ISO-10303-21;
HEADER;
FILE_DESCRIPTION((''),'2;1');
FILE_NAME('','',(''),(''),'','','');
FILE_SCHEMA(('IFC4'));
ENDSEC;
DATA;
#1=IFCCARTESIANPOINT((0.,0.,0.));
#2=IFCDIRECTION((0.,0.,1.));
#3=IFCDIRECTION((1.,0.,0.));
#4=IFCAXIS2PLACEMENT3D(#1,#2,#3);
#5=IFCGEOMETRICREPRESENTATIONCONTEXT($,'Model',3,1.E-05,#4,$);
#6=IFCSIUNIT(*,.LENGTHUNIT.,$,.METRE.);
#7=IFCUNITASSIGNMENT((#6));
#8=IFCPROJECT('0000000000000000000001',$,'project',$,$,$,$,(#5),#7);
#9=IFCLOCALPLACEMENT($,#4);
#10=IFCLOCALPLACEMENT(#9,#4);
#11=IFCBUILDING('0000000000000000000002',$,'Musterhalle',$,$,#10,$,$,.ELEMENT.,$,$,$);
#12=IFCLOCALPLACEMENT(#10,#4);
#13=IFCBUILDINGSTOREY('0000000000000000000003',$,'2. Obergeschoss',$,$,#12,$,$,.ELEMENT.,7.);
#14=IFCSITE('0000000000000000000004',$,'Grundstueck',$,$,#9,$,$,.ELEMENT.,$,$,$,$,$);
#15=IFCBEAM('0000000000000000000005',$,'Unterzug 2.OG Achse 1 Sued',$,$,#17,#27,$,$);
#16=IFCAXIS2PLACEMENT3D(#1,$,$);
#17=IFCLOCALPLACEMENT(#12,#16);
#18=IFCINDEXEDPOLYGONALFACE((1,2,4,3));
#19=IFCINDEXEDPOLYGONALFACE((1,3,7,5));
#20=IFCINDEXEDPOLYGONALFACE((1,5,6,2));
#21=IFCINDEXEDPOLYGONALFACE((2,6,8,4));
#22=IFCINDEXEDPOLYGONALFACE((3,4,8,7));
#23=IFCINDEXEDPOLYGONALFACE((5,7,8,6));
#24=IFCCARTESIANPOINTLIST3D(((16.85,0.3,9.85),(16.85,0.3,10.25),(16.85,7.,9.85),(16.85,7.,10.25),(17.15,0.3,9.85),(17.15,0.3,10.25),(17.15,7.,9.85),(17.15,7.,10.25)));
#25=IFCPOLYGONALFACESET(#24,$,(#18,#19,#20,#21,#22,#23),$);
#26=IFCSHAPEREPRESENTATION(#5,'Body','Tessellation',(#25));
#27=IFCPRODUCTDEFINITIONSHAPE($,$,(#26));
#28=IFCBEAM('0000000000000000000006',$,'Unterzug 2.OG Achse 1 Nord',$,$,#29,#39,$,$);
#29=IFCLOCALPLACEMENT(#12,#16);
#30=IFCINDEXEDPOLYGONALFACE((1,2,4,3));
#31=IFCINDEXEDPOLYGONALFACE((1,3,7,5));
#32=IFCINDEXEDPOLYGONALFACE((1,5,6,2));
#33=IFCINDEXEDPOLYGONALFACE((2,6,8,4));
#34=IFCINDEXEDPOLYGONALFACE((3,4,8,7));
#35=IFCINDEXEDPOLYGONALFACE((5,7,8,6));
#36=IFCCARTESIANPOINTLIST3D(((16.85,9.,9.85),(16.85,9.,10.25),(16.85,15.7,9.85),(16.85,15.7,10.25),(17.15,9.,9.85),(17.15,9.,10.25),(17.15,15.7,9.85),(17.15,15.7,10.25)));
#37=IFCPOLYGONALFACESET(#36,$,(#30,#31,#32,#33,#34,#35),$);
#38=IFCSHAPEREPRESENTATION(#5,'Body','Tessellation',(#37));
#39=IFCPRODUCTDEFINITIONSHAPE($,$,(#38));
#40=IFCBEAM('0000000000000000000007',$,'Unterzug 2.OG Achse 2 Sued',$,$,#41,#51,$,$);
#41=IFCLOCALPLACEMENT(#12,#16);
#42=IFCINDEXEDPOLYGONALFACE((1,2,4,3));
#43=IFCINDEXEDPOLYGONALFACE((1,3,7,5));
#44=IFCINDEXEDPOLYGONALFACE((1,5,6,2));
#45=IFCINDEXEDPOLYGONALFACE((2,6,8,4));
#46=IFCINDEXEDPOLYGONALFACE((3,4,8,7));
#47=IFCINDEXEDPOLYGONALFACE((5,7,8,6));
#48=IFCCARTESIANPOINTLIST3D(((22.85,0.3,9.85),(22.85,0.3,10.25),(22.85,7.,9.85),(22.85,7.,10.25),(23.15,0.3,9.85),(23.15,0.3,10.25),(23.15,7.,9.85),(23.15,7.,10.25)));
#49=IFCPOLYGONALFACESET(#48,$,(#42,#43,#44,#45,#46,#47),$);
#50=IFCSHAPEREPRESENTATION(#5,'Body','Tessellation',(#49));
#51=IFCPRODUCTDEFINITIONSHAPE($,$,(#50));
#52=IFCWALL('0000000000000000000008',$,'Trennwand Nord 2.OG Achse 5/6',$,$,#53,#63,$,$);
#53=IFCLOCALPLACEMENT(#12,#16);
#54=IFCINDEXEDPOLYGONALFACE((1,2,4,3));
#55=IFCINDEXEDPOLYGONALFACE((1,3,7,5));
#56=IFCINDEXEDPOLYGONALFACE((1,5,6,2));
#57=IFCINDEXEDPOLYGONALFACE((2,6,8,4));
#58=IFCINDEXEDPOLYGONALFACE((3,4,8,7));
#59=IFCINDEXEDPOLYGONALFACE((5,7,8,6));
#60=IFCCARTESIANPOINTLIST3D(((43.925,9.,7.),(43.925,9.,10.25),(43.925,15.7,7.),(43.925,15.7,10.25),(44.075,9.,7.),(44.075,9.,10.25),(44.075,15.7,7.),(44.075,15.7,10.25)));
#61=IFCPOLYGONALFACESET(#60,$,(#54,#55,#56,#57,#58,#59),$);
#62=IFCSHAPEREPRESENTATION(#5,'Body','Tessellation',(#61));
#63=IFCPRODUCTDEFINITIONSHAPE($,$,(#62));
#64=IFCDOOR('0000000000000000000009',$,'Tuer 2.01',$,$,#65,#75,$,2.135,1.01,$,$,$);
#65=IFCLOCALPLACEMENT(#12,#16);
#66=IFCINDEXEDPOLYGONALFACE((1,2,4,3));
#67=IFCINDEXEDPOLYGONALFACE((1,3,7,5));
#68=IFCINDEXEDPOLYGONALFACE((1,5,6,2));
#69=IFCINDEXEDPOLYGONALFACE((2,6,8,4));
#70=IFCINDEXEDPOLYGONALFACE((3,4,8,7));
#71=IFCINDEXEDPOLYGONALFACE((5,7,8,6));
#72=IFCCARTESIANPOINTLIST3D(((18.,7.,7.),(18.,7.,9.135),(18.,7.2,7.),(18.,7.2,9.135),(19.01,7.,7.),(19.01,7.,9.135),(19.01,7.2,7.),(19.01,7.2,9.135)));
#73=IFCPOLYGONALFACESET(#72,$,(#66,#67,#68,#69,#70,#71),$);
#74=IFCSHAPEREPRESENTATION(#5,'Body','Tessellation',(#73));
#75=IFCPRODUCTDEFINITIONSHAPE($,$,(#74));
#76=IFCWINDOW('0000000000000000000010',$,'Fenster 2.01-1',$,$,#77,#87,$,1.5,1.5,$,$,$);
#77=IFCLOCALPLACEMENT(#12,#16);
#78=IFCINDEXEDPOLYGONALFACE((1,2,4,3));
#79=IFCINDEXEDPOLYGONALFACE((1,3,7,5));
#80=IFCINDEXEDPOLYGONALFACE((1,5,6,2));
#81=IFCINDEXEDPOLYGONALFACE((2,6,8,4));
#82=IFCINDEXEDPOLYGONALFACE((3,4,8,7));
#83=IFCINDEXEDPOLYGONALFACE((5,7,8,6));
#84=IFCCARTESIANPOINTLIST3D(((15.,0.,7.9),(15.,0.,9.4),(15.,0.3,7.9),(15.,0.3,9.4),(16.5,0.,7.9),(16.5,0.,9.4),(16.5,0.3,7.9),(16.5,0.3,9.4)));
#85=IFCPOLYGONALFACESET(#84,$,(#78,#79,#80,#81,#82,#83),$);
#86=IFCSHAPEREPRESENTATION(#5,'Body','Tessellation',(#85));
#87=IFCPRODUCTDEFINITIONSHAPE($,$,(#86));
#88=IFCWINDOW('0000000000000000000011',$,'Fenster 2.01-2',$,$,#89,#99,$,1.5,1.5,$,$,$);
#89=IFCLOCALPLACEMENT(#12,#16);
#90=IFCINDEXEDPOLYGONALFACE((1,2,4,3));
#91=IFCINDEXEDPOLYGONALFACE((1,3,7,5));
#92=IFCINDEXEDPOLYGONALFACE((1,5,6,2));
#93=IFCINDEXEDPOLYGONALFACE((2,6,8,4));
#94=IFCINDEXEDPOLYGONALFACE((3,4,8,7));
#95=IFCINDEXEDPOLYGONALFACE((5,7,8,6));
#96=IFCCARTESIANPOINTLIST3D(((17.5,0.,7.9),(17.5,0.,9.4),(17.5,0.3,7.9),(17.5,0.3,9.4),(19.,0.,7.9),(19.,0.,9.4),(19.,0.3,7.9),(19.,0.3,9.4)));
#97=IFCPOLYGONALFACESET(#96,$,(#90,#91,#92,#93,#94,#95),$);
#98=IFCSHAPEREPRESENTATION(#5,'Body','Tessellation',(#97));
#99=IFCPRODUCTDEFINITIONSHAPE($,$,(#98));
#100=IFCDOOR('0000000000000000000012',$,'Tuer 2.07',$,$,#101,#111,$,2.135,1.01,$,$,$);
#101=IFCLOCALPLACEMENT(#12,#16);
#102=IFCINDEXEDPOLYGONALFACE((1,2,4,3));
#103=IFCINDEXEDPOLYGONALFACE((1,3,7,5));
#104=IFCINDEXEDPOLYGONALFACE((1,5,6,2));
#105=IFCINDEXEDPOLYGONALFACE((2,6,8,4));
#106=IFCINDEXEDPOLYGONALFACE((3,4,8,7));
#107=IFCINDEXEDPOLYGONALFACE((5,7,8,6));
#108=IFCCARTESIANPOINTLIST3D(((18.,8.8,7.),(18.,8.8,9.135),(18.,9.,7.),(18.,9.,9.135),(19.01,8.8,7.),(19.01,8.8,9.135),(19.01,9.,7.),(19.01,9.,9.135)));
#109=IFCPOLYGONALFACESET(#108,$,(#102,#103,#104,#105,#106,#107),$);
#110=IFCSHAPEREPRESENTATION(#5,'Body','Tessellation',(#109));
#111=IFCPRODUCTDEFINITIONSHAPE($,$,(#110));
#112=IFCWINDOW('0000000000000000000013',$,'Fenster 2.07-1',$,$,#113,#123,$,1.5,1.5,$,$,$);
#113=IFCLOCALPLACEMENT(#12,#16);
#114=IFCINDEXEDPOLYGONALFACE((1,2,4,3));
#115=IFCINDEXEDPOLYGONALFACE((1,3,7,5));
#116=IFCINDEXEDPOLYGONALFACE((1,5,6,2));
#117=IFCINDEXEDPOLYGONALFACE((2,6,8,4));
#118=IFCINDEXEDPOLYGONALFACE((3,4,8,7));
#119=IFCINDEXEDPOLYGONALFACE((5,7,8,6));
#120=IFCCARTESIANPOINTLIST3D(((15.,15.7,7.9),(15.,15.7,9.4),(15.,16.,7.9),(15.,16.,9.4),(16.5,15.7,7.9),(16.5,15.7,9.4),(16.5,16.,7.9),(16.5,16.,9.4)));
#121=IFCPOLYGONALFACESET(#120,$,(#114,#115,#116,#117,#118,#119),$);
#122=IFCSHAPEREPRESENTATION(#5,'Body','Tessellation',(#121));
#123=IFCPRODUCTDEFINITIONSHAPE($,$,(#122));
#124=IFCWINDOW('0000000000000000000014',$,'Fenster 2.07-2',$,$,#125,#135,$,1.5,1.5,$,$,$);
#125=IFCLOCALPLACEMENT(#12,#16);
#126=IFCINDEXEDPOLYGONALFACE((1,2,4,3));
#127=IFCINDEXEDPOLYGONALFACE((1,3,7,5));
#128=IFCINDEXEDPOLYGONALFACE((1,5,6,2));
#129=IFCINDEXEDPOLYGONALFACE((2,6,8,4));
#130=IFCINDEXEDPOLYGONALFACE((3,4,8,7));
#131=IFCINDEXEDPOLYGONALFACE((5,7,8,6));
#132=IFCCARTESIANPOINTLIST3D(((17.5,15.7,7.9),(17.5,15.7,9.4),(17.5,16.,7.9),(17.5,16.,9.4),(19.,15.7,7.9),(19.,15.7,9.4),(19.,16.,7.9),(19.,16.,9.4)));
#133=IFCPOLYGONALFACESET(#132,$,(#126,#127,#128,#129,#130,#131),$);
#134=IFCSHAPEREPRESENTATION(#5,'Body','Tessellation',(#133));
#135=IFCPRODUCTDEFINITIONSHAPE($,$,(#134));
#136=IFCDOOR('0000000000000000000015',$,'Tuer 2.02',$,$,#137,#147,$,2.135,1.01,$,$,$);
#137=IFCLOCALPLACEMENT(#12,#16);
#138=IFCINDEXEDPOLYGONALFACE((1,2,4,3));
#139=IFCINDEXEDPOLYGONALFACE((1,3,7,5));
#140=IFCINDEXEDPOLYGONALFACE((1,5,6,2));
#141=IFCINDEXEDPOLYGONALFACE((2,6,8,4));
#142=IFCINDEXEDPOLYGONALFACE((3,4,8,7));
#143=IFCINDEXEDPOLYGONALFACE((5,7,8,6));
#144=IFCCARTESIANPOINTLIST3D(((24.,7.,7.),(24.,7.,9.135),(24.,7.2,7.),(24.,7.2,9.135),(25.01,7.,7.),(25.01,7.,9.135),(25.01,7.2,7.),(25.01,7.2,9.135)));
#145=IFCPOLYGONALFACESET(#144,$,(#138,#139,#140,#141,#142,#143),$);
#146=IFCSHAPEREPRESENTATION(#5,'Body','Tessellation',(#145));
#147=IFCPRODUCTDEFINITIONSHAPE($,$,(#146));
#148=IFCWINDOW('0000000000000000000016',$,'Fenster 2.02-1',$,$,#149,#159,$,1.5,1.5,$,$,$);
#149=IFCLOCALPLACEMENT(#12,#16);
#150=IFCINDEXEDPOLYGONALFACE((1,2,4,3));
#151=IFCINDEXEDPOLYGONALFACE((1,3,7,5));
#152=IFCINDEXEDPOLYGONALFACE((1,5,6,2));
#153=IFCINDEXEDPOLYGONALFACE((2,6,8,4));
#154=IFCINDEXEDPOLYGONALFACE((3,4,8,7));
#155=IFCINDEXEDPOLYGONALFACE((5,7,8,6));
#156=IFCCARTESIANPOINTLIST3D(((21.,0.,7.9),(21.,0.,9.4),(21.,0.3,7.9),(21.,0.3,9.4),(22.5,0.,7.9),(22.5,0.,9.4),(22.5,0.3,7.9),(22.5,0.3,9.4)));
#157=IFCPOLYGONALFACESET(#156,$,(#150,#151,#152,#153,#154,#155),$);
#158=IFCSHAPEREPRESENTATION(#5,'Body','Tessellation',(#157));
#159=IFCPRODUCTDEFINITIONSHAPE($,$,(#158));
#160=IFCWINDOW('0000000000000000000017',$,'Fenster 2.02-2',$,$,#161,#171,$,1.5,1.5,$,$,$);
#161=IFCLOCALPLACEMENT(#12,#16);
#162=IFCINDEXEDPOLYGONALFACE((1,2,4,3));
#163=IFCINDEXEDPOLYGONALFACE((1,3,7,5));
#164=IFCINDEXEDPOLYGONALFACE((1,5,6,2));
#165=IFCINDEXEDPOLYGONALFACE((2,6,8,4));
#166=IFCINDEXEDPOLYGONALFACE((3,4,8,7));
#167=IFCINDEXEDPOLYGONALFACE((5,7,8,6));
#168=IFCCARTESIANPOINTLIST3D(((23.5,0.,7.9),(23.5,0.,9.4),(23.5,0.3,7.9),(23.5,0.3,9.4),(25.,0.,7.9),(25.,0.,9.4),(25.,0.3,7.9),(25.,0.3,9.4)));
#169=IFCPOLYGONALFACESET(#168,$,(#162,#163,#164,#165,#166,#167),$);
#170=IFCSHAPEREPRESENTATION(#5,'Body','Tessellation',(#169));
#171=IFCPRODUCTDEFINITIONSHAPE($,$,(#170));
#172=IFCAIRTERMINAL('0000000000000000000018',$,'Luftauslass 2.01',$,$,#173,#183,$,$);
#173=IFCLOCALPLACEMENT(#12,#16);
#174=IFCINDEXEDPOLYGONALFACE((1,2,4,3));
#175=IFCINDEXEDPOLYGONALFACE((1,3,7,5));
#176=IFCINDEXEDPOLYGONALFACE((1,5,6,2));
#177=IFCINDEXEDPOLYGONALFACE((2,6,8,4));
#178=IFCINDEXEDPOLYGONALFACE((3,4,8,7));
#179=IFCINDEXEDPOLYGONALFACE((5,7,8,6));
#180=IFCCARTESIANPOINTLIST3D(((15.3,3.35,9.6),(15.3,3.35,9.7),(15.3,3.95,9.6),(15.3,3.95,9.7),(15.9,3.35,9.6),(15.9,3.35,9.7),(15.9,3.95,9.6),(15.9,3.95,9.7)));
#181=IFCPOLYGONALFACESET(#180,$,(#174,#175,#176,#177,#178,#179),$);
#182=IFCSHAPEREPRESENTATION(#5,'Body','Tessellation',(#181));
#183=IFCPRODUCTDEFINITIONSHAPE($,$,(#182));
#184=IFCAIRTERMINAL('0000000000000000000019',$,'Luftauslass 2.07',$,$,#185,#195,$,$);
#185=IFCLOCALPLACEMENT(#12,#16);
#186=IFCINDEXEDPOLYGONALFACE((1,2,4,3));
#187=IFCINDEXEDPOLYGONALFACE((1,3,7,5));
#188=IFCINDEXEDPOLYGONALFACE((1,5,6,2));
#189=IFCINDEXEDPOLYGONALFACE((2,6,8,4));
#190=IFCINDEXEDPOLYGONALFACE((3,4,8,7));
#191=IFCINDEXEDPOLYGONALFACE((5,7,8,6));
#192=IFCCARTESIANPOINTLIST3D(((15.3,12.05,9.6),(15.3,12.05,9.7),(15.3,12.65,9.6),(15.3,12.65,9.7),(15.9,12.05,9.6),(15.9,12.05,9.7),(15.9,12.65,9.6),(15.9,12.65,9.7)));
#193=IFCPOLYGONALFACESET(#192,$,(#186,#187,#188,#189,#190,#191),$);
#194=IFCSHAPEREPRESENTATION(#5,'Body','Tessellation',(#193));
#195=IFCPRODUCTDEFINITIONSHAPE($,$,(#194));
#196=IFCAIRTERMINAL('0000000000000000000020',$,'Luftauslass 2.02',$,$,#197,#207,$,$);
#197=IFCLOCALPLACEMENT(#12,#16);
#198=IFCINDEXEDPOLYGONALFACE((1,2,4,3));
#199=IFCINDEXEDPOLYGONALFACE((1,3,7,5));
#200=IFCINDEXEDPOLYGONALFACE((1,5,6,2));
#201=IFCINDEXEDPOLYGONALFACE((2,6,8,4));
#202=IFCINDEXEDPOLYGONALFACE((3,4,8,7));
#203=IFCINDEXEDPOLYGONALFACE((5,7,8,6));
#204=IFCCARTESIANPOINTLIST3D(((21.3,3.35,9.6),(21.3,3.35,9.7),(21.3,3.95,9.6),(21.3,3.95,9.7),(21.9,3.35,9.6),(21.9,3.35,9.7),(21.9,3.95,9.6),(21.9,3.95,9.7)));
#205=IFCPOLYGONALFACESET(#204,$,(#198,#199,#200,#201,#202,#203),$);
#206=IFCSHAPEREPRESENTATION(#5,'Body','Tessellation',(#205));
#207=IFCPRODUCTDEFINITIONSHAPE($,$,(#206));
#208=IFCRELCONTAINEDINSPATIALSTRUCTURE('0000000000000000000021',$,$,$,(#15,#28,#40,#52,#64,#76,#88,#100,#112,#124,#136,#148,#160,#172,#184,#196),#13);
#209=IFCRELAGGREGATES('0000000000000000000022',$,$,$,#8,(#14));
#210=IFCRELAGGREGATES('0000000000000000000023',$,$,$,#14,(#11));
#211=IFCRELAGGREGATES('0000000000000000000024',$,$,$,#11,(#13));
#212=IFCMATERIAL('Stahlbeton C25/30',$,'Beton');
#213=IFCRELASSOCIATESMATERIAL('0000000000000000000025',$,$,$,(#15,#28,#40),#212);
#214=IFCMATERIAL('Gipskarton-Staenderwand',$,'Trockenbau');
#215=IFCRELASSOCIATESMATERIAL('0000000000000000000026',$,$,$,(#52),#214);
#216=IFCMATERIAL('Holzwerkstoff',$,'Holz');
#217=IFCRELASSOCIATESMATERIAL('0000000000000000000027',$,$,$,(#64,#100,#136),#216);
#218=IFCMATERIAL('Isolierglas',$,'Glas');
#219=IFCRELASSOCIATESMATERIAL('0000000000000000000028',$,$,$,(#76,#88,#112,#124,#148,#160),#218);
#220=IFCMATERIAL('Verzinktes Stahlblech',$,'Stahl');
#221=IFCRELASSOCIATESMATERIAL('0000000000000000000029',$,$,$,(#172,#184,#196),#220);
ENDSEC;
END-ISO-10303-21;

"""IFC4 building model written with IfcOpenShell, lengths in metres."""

from ifc_helpers import new_model, si_unit, frame, origin_with_axes, origin_2d, place, context, project, spatial, rectangle, extrude, material, element, save


model = new_model("IFC4")

# Units and contexts
model_context = context("Model", 3, precision=1e-05, world=origin_with_axes())
ifc_project = project(units=[si_unit("LENGTHUNIT", "METRE")], contexts=[model_context])

# Site, building, storey
site_placement = place(None, origin_with_axes())
site = spatial("IfcSite", under=ifc_project, at=site_placement, Name="Grundstueck", CompositionType="ELEMENT")
building_placement = place(site_placement, origin_with_axes())
building = spatial("IfcBuilding", under=site, at=building_placement, Name="Musterhalle", CompositionType="ELEMENT")
storey_placement = place(building_placement, origin_with_axes())
storey = spatial("IfcBuildingStorey", under=building, at=storey_placement, Name="2. Obergeschoss", CompositionType="ELEMENT", Elevation=7.0)

# Beams
ifc_material_1 = material(Name="Stahlbeton C25/30", Category="Beton")
placement = place(storey_placement, origin_with_axes())
element("IfcBeam", 1, at=placement, inside=storey, material=ifc_material_1, Name="Unterzug 2.OG Achse 1 Sued", context=model_context, shape_type="SweptSolid", body=[
    extrude(rectangle(XDim=0.3, YDim=6.7, at=origin_2d()), frame((17.0, 3.65, 9.85), z_axis=(0.0, 0.0, 1.0), x_axis=(1.0, 0.0, 0.0)), (0.0, 0.0, 1.0), 0.4),
])
element("IfcBeam", 2, at=placement, inside=storey, material=ifc_material_1, Name="Unterzug 2.OG Achse 1 Nord", context=model_context, shape_type="SweptSolid", body=[
    extrude(rectangle(XDim=0.3, YDim=6.7, at=origin_2d()), frame((17.0, 12.35, 9.85), z_axis=(0.0, 0.0, 1.0), x_axis=(1.0, 0.0, 0.0)), (0.0, 0.0, 1.0), 0.4),
])
element("IfcBeam", 3, at=placement, inside=storey, material=ifc_material_1, Name="Unterzug 2.OG Achse 2 Sued", context=model_context, shape_type="SweptSolid", body=[
    extrude(rectangle(XDim=0.3, YDim=6.7, at=origin_2d()), frame((23.0, 3.65, 9.85), z_axis=(0.0, 0.0, 1.0), x_axis=(1.0, 0.0, 0.0)), (0.0, 0.0, 1.0), 0.4),
])

# Wall
ifc_material_2 = material(Name="Gipskarton-Staenderwand", Category="Trockenbau")
element("IfcWall", 4, at=placement, inside=storey, material=ifc_material_2, Name="Trennwand Nord 2.OG Achse 5/6", context=model_context, shape_type="SweptSolid", body=[
    extrude(rectangle(XDim=0.15, YDim=6.7, at=origin_2d()), frame((44.0, 12.35, 7.0), z_axis=(0.0, 0.0, 1.0), x_axis=(1.0, 0.0, 0.0)), (0.0, 0.0, 1.0), 3.25),
])

# Door
ifc_material_3 = material(Name="Holzwerkstoff", Category="Holz")
element("IfcDoor", 5, at=placement, inside=storey, material=ifc_material_3, Name="Tuer 2.01", OverallHeight=2.135, OverallWidth=1.01, context=model_context, shape_type="SweptSolid", body=[
    extrude(rectangle(XDim=1.01, YDim=0.2, at=origin_2d()), frame((18.505, 7.1, 7.0), z_axis=(0.0, 0.0, 1.0), x_axis=(1.0, 0.0, 0.0)), (0.0, 0.0, 1.0), 2.135),
])

# Windows
ifc_material_4 = material(Name="Isolierglas", Category="Glas")
element("IfcWindow", 6, at=placement, inside=storey, material=ifc_material_4, Name="Fenster 2.01-1", OverallHeight=1.5, OverallWidth=1.5, context=model_context, shape_type="SweptSolid", body=[
    extrude(rectangle(XDim=1.5, YDim=0.3, at=origin_2d()), frame((15.75, 0.15, 7.9), z_axis=(0.0, 0.0, 1.0), x_axis=(1.0, 0.0, 0.0)), (0.0, 0.0, 1.0), 1.5),
])
element("IfcWindow", 7, at=placement, inside=storey, material=ifc_material_4, Name="Fenster 2.01-2", OverallHeight=1.5, OverallWidth=1.5, context=model_context, shape_type="SweptSolid", body=[
    extrude(rectangle(XDim=1.5, YDim=0.3, at=origin_2d()), frame((18.25, 0.15, 7.9), z_axis=(0.0, 0.0, 1.0), x_axis=(1.0, 0.0, 0.0)), (0.0, 0.0, 1.0), 1.5),
])

# Door
element("IfcDoor", 8, at=placement, inside=storey, material=ifc_material_3, Name="Tuer 2.07", OverallHeight=2.135, OverallWidth=1.01, context=model_context, shape_type="SweptSolid", body=[
    extrude(rectangle(XDim=1.01, YDim=0.2, at=origin_2d()), frame((18.505, 8.9, 7.0), z_axis=(0.0, 0.0, 1.0), x_axis=(1.0, 0.0, 0.0)), (0.0, 0.0, 1.0), 2.135),
])

# Windows
element("IfcWindow", 9, at=placement, inside=storey, material=ifc_material_4, Name="Fenster 2.07-1", OverallHeight=1.5, OverallWidth=1.5, context=model_context, shape_type="SweptSolid", body=[
    extrude(rectangle(XDim=1.5, YDim=0.3, at=origin_2d()), frame((15.75, 15.85, 7.9), z_axis=(0.0, 0.0, 1.0), x_axis=(1.0, 0.0, 0.0)), (0.0, 0.0, 1.0), 1.5),
])
element("IfcWindow", 10, at=placement, inside=storey, material=ifc_material_4, Name="Fenster 2.07-2", OverallHeight=1.5, OverallWidth=1.5, context=model_context, shape_type="SweptSolid", body=[
    extrude(rectangle(XDim=1.5, YDim=0.3, at=origin_2d()), frame((18.25, 15.85, 7.9), z_axis=(0.0, 0.0, 1.0), x_axis=(1.0, 0.0, 0.0)), (0.0, 0.0, 1.0), 1.5),
])

# Door
element("IfcDoor", 11, at=placement, inside=storey, material=ifc_material_3, Name="Tuer 2.02", OverallHeight=2.135, OverallWidth=1.01, context=model_context, shape_type="SweptSolid", body=[
    extrude(rectangle(XDim=1.01, YDim=0.2, at=origin_2d()), frame((24.505, 7.1, 7.0), z_axis=(0.0, 0.0, 1.0), x_axis=(1.0, 0.0, 0.0)), (0.0, 0.0, 1.0), 2.135),
])

# Windows
element("IfcWindow", 12, at=placement, inside=storey, material=ifc_material_4, Name="Fenster 2.02-1", OverallHeight=1.5, OverallWidth=1.5, context=model_context, shape_type="SweptSolid", body=[
    extrude(rectangle(XDim=1.5, YDim=0.3, at=origin_2d()), frame((21.75, 0.15, 7.9), z_axis=(0.0, 0.0, 1.0), x_axis=(1.0, 0.0, 0.0)), (0.0, 0.0, 1.0), 1.5),
])
element("IfcWindow", 13, at=placement, inside=storey, material=ifc_material_4, Name="Fenster 2.02-2", OverallHeight=1.5, OverallWidth=1.5, context=model_context, shape_type="SweptSolid", body=[
    extrude(rectangle(XDim=1.5, YDim=0.3, at=origin_2d()), frame((24.25, 0.15, 7.9), z_axis=(0.0, 0.0, 1.0), x_axis=(1.0, 0.0, 0.0)), (0.0, 0.0, 1.0), 1.5),
])

# Air terminals
ifc_material_5 = material(Name="Verzinktes Stahlblech", Category="Stahl")
element("IfcAirTerminal", 14, at=placement, inside=storey, material=ifc_material_5, Name="Luftauslass 2.01", context=model_context, shape_type="SweptSolid", body=[
    extrude(rectangle(XDim=0.6, YDim=0.6, at=origin_2d()), frame((15.6, 3.65, 9.6), z_axis=(0.0, 0.0, 1.0), x_axis=(1.0, 0.0, 0.0)), (0.0, 0.0, 1.0), 0.1),
])
element("IfcAirTerminal", 15, at=placement, inside=storey, material=ifc_material_5, Name="Luftauslass 2.07", context=model_context, shape_type="SweptSolid", body=[
    extrude(rectangle(XDim=0.6, YDim=0.6, at=origin_2d()), frame((15.6, 12.35, 9.6), z_axis=(0.0, 0.0, 1.0), x_axis=(1.0, 0.0, 0.0)), (0.0, 0.0, 1.0), 0.1),
])
element("IfcAirTerminal", 16, at=placement, inside=storey, material=ifc_material_5, Name="Luftauslass 2.02", context=model_context, shape_type="SweptSolid", body=[
    extrude(rectangle(XDim=0.6, YDim=0.6, at=origin_2d()), frame((21.6, 3.65, 9.6), z_axis=(0.0, 0.0, 1.0), x_axis=(1.0, 0.0, 0.0)), (0.0, 0.0, 1.0), 0.1),
])

save(model, "model.ifc")
